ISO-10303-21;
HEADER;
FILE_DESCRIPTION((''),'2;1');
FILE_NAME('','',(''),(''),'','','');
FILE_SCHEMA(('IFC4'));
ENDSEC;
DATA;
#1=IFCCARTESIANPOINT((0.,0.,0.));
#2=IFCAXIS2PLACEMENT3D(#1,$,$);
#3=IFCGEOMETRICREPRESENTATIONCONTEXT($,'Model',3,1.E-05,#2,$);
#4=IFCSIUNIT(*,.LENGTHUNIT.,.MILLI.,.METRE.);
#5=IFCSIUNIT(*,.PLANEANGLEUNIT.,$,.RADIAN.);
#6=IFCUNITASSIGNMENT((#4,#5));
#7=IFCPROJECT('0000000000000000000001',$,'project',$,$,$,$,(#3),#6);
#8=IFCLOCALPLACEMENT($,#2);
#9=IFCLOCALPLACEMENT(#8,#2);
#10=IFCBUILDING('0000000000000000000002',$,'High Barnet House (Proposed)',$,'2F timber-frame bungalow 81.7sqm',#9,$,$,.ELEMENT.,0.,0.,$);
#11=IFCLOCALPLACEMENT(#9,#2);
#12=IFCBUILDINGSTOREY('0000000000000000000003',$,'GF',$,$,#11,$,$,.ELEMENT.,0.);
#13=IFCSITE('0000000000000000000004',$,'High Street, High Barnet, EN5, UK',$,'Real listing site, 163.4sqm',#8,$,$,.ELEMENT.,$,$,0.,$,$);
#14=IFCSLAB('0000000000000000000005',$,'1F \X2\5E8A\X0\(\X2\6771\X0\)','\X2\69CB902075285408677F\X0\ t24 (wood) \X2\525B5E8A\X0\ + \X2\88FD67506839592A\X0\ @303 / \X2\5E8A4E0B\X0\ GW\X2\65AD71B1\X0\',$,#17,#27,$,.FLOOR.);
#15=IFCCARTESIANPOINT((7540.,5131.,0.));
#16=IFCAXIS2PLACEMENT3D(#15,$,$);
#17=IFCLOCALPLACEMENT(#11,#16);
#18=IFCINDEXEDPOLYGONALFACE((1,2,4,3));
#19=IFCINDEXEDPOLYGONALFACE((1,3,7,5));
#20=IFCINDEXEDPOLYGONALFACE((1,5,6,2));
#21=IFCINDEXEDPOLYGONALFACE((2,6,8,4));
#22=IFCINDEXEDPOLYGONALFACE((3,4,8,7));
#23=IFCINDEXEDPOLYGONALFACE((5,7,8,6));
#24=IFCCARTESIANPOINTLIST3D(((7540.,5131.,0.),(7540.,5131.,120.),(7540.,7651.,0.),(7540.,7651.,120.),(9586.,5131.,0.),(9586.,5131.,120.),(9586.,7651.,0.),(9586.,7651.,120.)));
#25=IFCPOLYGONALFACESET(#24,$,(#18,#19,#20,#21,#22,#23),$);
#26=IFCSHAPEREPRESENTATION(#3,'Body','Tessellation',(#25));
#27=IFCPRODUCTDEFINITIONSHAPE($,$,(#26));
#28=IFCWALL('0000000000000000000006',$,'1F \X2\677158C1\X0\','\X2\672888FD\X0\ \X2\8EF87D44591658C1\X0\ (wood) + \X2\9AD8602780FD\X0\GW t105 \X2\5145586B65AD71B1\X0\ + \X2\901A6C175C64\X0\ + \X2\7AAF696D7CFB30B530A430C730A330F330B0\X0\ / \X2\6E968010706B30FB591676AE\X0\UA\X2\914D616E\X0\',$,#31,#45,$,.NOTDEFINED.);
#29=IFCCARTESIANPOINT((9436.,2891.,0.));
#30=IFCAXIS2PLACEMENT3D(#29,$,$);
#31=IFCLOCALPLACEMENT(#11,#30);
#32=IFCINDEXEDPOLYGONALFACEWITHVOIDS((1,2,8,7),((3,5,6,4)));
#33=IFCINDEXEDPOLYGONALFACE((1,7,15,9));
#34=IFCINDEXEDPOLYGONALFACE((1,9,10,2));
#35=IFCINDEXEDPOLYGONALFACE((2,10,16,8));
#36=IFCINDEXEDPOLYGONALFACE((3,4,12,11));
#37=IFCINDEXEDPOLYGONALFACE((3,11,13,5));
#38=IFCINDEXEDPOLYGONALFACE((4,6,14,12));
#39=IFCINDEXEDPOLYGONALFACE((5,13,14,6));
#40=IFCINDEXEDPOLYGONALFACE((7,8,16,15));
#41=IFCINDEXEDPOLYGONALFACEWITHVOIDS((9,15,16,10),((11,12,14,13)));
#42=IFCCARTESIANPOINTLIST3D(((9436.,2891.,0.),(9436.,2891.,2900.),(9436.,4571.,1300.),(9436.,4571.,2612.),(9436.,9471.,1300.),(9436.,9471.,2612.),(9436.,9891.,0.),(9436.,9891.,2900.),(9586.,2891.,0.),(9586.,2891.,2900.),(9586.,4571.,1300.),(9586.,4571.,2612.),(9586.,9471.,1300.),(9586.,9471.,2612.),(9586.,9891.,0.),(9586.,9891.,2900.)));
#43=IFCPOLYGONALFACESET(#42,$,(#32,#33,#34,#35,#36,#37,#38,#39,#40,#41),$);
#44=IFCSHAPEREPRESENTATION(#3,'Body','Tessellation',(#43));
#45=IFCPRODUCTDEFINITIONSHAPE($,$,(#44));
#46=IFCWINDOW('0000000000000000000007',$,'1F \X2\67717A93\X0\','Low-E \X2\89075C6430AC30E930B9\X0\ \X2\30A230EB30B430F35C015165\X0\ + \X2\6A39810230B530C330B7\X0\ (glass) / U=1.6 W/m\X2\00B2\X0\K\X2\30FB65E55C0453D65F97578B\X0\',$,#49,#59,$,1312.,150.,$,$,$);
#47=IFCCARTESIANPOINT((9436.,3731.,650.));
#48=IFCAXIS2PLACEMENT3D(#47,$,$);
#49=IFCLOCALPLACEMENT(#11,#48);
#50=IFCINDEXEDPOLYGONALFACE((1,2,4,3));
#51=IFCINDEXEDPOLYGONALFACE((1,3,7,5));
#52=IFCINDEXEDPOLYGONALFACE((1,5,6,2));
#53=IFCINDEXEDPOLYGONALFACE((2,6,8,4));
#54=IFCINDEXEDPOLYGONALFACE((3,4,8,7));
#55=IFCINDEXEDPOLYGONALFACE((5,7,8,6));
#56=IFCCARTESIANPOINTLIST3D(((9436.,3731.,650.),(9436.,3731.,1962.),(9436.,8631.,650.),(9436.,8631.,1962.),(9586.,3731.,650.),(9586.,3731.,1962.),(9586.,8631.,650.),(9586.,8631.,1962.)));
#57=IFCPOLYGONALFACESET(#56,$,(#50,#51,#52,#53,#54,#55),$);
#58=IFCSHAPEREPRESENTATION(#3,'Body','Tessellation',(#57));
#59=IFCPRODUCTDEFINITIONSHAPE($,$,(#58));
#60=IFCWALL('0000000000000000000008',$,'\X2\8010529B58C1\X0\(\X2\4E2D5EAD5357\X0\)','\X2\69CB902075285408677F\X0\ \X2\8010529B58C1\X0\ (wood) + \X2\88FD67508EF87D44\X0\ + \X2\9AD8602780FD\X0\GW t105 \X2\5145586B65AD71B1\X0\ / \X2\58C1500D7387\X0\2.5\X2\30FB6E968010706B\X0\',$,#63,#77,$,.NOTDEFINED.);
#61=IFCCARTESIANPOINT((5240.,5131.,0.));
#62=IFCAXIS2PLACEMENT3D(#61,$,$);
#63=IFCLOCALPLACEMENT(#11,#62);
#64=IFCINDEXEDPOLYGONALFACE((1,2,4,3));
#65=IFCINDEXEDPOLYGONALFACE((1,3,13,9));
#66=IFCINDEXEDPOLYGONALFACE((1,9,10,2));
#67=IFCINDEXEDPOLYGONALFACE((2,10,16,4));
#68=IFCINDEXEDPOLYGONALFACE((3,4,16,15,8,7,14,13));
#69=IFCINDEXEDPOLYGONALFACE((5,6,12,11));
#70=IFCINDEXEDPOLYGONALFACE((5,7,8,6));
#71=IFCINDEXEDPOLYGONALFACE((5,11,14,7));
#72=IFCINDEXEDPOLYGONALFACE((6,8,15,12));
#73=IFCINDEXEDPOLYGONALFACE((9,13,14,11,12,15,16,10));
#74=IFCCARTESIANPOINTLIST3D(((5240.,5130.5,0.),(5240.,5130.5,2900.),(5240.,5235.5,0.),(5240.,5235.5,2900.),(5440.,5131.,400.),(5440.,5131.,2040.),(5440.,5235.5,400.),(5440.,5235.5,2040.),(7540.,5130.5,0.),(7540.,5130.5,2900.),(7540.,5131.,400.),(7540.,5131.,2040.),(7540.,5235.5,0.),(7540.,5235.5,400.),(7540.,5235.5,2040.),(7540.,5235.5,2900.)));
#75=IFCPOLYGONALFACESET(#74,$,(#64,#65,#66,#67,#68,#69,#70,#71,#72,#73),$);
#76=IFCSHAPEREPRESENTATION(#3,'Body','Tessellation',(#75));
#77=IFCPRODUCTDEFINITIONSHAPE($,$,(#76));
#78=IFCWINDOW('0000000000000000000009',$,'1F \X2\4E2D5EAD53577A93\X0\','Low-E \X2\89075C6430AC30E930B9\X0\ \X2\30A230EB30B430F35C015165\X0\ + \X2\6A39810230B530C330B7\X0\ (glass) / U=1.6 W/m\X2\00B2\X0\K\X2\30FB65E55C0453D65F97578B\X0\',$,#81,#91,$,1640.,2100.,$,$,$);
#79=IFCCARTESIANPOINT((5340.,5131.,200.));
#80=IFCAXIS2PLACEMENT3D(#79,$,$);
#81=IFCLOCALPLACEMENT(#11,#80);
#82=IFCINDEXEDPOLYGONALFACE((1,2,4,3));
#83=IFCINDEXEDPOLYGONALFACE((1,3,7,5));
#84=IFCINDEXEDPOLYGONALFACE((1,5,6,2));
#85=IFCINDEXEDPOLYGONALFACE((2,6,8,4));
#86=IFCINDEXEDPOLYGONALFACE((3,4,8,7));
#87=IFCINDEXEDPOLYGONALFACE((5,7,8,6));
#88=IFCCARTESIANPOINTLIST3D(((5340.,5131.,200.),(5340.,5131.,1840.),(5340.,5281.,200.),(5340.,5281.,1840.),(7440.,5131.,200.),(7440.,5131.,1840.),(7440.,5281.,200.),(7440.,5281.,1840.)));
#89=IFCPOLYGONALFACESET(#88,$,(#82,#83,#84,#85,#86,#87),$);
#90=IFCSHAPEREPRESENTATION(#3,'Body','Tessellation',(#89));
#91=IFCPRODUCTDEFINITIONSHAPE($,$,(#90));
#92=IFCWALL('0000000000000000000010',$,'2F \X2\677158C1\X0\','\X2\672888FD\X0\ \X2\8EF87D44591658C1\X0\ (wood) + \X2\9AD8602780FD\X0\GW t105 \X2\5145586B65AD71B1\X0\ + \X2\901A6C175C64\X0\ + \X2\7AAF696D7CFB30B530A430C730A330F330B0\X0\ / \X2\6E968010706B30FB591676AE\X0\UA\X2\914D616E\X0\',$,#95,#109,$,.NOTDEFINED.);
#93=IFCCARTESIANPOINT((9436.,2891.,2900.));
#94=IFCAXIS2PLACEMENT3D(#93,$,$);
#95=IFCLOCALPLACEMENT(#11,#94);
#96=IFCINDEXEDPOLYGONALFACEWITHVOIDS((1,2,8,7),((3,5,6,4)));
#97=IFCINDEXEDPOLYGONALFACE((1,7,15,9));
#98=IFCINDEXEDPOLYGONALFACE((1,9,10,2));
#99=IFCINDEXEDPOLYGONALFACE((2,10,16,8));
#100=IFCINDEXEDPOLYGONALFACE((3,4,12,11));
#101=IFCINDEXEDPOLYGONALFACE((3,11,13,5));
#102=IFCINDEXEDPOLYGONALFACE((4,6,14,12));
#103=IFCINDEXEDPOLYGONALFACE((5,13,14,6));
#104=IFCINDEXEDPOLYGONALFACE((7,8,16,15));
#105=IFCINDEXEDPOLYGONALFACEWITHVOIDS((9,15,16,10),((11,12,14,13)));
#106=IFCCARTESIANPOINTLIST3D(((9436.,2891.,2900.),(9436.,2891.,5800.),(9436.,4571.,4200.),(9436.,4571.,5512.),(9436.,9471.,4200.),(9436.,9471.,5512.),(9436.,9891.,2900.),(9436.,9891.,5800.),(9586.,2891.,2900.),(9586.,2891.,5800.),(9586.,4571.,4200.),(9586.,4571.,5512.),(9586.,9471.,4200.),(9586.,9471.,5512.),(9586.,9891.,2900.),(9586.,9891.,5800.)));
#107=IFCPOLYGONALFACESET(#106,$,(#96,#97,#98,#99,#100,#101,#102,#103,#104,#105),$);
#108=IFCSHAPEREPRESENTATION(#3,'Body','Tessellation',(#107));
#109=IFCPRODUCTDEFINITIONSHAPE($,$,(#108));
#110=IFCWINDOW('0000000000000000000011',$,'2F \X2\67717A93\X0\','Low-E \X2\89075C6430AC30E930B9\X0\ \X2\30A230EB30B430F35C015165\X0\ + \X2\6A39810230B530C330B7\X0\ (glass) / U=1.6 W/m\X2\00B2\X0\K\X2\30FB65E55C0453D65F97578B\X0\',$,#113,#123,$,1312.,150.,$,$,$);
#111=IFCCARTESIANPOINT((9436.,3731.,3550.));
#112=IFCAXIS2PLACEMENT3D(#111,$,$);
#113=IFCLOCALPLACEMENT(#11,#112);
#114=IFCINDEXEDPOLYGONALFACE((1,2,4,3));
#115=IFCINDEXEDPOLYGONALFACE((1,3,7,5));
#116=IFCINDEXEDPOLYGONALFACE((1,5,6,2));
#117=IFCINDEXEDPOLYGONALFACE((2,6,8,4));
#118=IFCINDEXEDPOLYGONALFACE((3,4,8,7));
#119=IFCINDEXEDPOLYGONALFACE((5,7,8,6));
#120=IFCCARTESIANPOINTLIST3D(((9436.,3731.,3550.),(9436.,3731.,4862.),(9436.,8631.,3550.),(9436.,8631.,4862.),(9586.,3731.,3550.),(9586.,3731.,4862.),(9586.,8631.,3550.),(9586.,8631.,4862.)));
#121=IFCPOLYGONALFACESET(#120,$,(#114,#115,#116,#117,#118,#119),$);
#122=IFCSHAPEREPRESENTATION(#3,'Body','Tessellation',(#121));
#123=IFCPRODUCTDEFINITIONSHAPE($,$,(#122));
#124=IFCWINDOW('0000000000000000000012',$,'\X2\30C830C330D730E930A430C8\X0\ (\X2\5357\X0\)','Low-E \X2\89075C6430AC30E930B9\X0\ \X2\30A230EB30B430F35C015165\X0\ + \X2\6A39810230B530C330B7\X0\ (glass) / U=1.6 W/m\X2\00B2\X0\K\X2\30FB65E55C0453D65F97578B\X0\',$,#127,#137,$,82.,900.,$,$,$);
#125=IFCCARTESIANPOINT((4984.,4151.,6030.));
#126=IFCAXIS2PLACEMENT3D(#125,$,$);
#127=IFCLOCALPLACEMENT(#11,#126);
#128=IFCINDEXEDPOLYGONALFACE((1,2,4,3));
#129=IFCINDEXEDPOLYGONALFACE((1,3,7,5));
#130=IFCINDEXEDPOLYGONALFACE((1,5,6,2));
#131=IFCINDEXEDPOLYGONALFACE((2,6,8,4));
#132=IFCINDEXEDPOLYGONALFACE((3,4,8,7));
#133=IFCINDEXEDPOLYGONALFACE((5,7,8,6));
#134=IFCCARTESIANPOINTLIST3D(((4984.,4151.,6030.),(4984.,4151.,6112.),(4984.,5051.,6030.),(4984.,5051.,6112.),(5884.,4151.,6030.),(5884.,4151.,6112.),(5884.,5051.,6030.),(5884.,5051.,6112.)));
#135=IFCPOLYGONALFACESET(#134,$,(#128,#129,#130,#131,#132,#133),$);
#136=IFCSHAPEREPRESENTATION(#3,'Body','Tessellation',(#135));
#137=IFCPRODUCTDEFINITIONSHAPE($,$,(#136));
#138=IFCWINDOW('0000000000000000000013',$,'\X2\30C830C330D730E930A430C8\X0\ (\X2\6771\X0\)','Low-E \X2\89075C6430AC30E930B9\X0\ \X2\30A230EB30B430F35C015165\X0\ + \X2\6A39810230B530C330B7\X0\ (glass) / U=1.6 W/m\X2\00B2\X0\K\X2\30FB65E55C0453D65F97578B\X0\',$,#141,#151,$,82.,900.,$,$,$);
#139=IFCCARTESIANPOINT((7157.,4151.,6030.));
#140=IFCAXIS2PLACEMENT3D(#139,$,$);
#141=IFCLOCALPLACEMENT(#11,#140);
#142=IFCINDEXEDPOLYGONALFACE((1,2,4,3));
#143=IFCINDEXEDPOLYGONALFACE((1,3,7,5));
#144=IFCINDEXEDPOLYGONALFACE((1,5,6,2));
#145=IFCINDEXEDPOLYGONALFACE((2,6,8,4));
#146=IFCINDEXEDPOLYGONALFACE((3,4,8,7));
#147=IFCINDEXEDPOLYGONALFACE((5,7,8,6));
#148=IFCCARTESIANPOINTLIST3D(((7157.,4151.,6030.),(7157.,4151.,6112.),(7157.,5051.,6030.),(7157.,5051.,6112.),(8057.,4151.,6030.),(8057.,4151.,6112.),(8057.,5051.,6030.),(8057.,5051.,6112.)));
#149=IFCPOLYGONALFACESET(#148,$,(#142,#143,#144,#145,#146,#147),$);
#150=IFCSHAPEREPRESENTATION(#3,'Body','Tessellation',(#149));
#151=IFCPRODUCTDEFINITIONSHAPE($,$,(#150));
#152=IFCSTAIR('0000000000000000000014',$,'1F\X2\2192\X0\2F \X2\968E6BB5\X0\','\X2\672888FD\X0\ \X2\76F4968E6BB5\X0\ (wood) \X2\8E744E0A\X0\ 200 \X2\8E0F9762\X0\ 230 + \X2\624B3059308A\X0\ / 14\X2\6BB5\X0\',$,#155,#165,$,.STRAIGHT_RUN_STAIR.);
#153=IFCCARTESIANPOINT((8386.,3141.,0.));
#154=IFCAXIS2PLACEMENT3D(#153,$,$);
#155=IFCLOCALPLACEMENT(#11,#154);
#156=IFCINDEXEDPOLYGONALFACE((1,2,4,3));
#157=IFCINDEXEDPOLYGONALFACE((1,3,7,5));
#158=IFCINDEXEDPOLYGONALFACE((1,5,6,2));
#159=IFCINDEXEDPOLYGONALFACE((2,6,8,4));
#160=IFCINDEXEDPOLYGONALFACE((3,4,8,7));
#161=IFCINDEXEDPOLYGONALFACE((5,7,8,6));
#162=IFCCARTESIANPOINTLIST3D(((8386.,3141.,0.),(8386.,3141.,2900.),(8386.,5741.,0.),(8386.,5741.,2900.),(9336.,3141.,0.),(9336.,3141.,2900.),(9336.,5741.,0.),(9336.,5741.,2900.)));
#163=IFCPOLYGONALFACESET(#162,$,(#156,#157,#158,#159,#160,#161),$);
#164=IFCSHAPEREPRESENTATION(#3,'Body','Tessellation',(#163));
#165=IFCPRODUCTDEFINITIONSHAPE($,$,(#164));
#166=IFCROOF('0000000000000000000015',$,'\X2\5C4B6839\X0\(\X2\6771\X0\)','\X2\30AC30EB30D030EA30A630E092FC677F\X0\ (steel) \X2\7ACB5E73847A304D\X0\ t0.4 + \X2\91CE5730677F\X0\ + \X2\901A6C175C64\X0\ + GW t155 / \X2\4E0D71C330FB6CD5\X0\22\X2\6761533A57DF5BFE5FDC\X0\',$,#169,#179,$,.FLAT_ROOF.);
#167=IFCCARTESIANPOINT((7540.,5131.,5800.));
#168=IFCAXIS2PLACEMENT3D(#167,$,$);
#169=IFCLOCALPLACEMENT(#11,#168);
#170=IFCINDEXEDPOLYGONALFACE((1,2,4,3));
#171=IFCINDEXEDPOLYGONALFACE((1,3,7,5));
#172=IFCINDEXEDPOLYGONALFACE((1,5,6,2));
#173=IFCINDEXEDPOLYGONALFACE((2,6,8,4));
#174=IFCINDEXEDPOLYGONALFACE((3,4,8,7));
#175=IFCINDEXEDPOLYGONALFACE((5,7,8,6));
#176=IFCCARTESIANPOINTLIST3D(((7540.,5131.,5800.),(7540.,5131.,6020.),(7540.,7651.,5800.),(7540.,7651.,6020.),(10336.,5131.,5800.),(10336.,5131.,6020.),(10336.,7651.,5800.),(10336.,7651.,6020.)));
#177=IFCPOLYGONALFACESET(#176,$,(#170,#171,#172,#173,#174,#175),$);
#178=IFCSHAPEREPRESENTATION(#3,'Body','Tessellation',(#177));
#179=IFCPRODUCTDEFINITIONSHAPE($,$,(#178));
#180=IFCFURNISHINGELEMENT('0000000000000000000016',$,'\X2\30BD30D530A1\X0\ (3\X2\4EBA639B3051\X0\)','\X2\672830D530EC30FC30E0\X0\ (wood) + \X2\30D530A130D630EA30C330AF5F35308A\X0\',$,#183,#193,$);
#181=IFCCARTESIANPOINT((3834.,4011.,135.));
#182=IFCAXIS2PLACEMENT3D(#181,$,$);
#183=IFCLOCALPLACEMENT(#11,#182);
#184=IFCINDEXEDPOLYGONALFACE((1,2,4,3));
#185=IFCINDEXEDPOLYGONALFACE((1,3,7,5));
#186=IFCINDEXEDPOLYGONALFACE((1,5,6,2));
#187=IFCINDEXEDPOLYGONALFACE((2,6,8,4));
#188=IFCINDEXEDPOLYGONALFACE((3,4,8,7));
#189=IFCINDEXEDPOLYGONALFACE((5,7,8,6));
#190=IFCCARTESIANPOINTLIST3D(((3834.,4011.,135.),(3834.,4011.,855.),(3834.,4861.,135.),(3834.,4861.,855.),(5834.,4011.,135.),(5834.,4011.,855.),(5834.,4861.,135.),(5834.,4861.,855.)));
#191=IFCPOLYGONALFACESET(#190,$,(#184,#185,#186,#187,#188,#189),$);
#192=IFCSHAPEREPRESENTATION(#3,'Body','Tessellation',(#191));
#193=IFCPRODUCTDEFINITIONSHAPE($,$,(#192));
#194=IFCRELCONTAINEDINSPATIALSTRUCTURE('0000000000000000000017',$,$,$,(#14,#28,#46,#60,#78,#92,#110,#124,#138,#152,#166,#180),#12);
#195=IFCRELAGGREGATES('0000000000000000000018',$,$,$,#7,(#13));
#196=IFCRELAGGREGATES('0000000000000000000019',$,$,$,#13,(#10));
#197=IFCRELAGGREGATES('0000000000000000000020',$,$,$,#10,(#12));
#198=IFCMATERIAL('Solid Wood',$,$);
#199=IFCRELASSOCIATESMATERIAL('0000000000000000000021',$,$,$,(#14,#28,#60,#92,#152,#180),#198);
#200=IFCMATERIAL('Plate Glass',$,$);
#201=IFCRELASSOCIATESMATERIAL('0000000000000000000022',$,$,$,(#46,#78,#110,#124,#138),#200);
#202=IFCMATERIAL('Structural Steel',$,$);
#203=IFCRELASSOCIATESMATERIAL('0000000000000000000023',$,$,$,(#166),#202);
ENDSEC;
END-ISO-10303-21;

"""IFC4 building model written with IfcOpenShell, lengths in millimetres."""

from ifc_helpers import new_model, si_unit, frame, frame_2d, origin, place, context, project, spatial, rectangle, extrude, material, element, fill, save


model = new_model("IFC4")

# Units and contexts
model_context = context("Model", 3, precision=1e-05, world=origin())
ifc_project = project(units=[si_unit("LENGTHUNIT", "METRE", prefix="MILLI"), si_unit("PLANEANGLEUNIT", "RADIAN")], contexts=[model_context])

# Site, building, storey
site_placement = place(None, origin())
site = spatial("IfcSite", under=ifc_project, at=site_placement, Name="High Street, High Barnet, EN5, UK", ObjectType="Real listing site, 163.4sqm", CompositionType="ELEMENT", RefElevation=0.0)
building_placement = place(site_placement, origin())
building = spatial("IfcBuilding", under=site, at=building_placement, Name="High Barnet House (Proposed)", ObjectType="2F timber-frame bungalow 81.7sqm", CompositionType="ELEMENT", ElevationOfRefHeight=0.0, ElevationOfTerrain=0.0)
storey_placement = place(building_placement, origin())
storey = spatial("IfcBuildingStorey", under=building, at=storey_placement, Name="GF", CompositionType="ELEMENT", Elevation=0.0)

# Slab
ifc_material_1 = material(Name="Solid Wood")
slab_placement = place(storey_placement, frame((7540.0, 5131.0, 0.0)))
element("IfcSlab", 1, at=slab_placement, inside=storey, material=ifc_material_1, Name="1F 床(東)", Description="構造用合板 t24 (wood) 剛床 + 製材根太 @303 / 床下 GW断熱", PredefinedType="FLOOR", context=model_context, shape_type="SweptSolid", body=[
    extrude(rectangle(XDim=2046.0, YDim=2520.0, at=frame_2d((1023.0, 1260.0))), frame((7540.0, 5131.0, 0.0)), (0.0, 0.0, 1.0), 120.0),
])

# Walls, openings, windows
wall_1_placement = place(storey_placement, frame((9436.0, 2891.0, 0.0)))
wall_1 = element("IfcWall", 2, at=wall_1_placement, inside=storey, material=ifc_material_1, Name="1F 東壁", Description="木製 軸組外壁 (wood) + 高性能GW t105 充填断熱 + 通気層 + 窯業系サイディング / 準耐火・外皮UA配慮", PredefinedType="NOTDEFINED", context=model_context, shape_type="SweptSolid", body=[
    extrude(rectangle(XDim=150.0, YDim=7000.0, at=frame_2d((75.0, 3500.0))), frame((9436.0, 2891.0, 0.0)), (0.0, 0.0, 1.0), 2900.0),
])
opening_1_placement = place(storey_placement, frame((9436.0, 3731.0, 650.0)))
opening_1 = element("IfcOpeningElement", 3, at=opening_1_placement, cuts=wall_1, PredefinedType="NOTDEFINED", context=model_context, shape_type="SweptSolid", body=[
    extrude(rectangle(XDim=150.0, YDim=4900.0, at=frame_2d((75.0, 2450.0))), frame((9436.0, 3731.0, 650.0)), (0.0, 0.0, 1.0), 1312.0),
])
ifc_material_2 = material(Name="Plate Glass")
window_1_placement = place(storey_placement, frame((9436.0, 3731.0, 650.0)))
window_1 = element("IfcWindow", 4, at=window_1_placement, inside=storey, material=ifc_material_2, Name="1F 東窓", Description="Low-E 複層ガラス アルゴン封入 + 樹脂サッシ (glass) / U=1.6 W/m²K・日射取得型", OverallHeight=1312.0, OverallWidth=150.0, context=model_context, shape_type="SweptSolid", body=[
    extrude(rectangle(XDim=150.0, YDim=4900.0, at=frame_2d((75.0, 2450.0))), frame((9436.0, 3731.0, 650.0)), (0.0, 0.0, 1.0), 1312.0),
])
fill(opening_1, window_1)
wall_2_placement = place(storey_placement, frame((5240.0, 5131.0, 0.0)))
wall_2 = element("IfcWall", 5, at=wall_2_placement, inside=storey, material=ifc_material_1, Name="耐力壁(中庭南)", Description="構造用合板 耐力壁 (wood) + 製材軸組 + 高性能GW t105 充填断熱 / 壁倍率2.5・準耐火", PredefinedType="NOTDEFINED", context=model_context, shape_type="SweptSolid", body=[
    extrude(rectangle(XDim=2300.0, YDim=105.0, at=frame_2d((1150.0, 52.0))), frame((5240.0, 5131.0, 0.0)), (0.0, 0.0, 1.0), 2900.0),
])
opening_2_placement = place(storey_placement, frame((5340.0, 5131.0, 200.0)))
opening_2 = element("IfcOpeningElement", 6, at=opening_2_placement, cuts=wall_2, PredefinedType="NOTDEFINED", context=model_context, shape_type="SweptSolid", body=[
    extrude(rectangle(XDim=2100.0, YDim=150.0, at=frame_2d((1050.0, 75.0))), frame((5340.0, 5131.0, 200.0)), (0.0, 0.0, 1.0), 1640.0),
])
window_2_placement = place(storey_placement, frame((5340.0, 5131.0, 200.0)))
window_2 = element("IfcWindow", 7, at=window_2_placement, inside=storey, material=ifc_material_2, Name="1F 中庭南窓", Description="Low-E 複層ガラス アルゴン封入 + 樹脂サッシ (glass) / U=1.6 W/m²K・日射取得型", OverallHeight=1640.0, OverallWidth=2100.0, context=model_context, shape_type="SweptSolid", body=[
    extrude(rectangle(XDim=2100.0, YDim=150.0, at=frame_2d((1050.0, 75.0))), frame((5340.0, 5131.0, 200.0)), (0.0, 0.0, 1.0), 1640.0),
])
fill(opening_2, window_2)

# Wall, opening, window
wall_3_placement = place(storey_placement, frame((9436.0, 2891.0, 2900.0)))
wall_3 = element("IfcWall", 8, at=wall_3_placement, inside=storey, material=ifc_material_1, Name="2F 東壁", Description="木製 軸組外壁 (wood) + 高性能GW t105 充填断熱 + 通気層 + 窯業系サイディング / 準耐火・外皮UA配慮", PredefinedType="NOTDEFINED", context=model_context, shape_type="SweptSolid", body=[
    extrude(rectangle(XDim=150.0, YDim=7000.0, at=frame_2d((75.0, 3500.0))), frame((9436.0, 2891.0, 2900.0)), (0.0, 0.0, 1.0), 2900.0),
])
opening_3_placement = place(storey_placement, frame((9436.0, 3731.0, 3550.0)))
opening_3 = element("IfcOpeningElement", 9, at=opening_3_placement, cuts=wall_3, PredefinedType="NOTDEFINED", context=model_context, shape_type="SweptSolid", body=[
    extrude(rectangle(XDim=150.0, YDim=4900.0, at=frame_2d((75.0, 2450.0))), frame((9436.0, 3731.0, 3550.0)), (0.0, 0.0, 1.0), 1312.0),
])
window_3_placement = place(storey_placement, frame((9436.0, 3731.0, 3550.0)))
window_3 = element("IfcWindow", 10, at=window_3_placement, inside=storey, material=ifc_material_2, Name="2F 東窓", Description="Low-E 複層ガラス アルゴン封入 + 樹脂サッシ (glass) / U=1.6 W/m²K・日射取得型", OverallHeight=1312.0, OverallWidth=150.0, context=model_context, shape_type="SweptSolid", body=[
    extrude(rectangle(XDim=150.0, YDim=4900.0, at=frame_2d((75.0, 2450.0))), frame((9436.0, 3731.0, 3550.0)), (0.0, 0.0, 1.0), 1312.0),
])
fill(opening_3, window_3)

# Windows
window_4_placement = place(storey_placement, frame((4984.0, 4151.0, 6030.0)))
element("IfcWindow", 11, at=window_4_placement, inside=storey, material=ifc_material_2, Name="トップライト (南)", Description="Low-E 複層ガラス アルゴン封入 + 樹脂サッシ (glass) / U=1.6 W/m²K・日射取得型", OverallHeight=82.0, OverallWidth=900.0, context=model_context, shape_type="SweptSolid", body=[
    extrude(rectangle(XDim=900.0, YDim=900.0, at=frame_2d((450.0, 450.0))), frame((4984.0, 4151.0, 6030.0)), (0.0, 0.0, 1.0), 82.0),
])
window_5_placement = place(storey_placement, frame((7157.0, 4151.0, 6030.0)))
element("IfcWindow", 12, at=window_5_placement, inside=storey, material=ifc_material_2, Name="トップライト (東)", Description="Low-E 複層ガラス アルゴン封入 + 樹脂サッシ (glass) / U=1.6 W/m²K・日射取得型", OverallHeight=82.0, OverallWidth=900.0, context=model_context, shape_type="SweptSolid", body=[
    extrude(rectangle(XDim=900.0, YDim=900.0, at=frame_2d((450.0, 450.0))), frame((7157.0, 4151.0, 6030.0)), (0.0, 0.0, 1.0), 82.0),
])

# Stair
stair_placement = place(storey_placement, frame((8386.0, 3141.0, 0.0)))
element("IfcStair", 13, at=stair_placement, inside=storey, material=ifc_material_1, Name="1F→2F 階段", Description="木製 直階段 (wood) 蹴上 200 踏面 230 + 手すり / 14段", PredefinedType="STRAIGHT_RUN_STAIR", context=model_context, shape_type="SweptSolid", body=[
    extrude(rectangle(XDim=950.0, YDim=2600.0, at=frame_2d((475.0, 1300.0))), frame((8386.0, 3141.0, 0.0)), (0.0, 0.0, 1.0), 2900.0),
])

# Roof
ifc_material_3 = material(Name="Structural Steel")
roof_placement = place(storey_placement, frame((7540.0, 5131.0, 5800.0)))
element("IfcRoof", 14, at=roof_placement, inside=storey, material=ifc_material_3, Name="屋根(東)", Description="ガルバリウム鋼板 (steel) 立平葺き t0.4 + 野地板 + 通気層 + GW t155 / 不燃・法22条区域対応", PredefinedType="FLAT_ROOF", context=model_context, shape_type="SweptSolid", body=[
    extrude(rectangle(XDim=2796.0, YDim=2520.0, at=frame_2d((1398.0, 1260.0))), frame((7540.0, 5131.0, 5800.0)), (0.0, 0.0, 1.0), 220.0),
])

# Furnishing element
furnishing_1_placement = place(storey_placement, frame((3834.0, 4011.0, 135.0)))
element("IfcFurnishingElement", 15, at=furnishing_1_placement, inside=storey, material=ifc_material_1, Name="ソファ (3人掛け)", Description="木フレーム (wood) + ファブリック張り", context=model_context, shape_type="SweptSolid", body=[
    extrude(rectangle(XDim=2000.0, YDim=850.0, at=frame_2d((1000.0, 425.0))), frame((3834.0, 4011.0, 135.0)), (0.0, 0.0, 1.0), 720.0),
])

save(model, "model.ifc")
